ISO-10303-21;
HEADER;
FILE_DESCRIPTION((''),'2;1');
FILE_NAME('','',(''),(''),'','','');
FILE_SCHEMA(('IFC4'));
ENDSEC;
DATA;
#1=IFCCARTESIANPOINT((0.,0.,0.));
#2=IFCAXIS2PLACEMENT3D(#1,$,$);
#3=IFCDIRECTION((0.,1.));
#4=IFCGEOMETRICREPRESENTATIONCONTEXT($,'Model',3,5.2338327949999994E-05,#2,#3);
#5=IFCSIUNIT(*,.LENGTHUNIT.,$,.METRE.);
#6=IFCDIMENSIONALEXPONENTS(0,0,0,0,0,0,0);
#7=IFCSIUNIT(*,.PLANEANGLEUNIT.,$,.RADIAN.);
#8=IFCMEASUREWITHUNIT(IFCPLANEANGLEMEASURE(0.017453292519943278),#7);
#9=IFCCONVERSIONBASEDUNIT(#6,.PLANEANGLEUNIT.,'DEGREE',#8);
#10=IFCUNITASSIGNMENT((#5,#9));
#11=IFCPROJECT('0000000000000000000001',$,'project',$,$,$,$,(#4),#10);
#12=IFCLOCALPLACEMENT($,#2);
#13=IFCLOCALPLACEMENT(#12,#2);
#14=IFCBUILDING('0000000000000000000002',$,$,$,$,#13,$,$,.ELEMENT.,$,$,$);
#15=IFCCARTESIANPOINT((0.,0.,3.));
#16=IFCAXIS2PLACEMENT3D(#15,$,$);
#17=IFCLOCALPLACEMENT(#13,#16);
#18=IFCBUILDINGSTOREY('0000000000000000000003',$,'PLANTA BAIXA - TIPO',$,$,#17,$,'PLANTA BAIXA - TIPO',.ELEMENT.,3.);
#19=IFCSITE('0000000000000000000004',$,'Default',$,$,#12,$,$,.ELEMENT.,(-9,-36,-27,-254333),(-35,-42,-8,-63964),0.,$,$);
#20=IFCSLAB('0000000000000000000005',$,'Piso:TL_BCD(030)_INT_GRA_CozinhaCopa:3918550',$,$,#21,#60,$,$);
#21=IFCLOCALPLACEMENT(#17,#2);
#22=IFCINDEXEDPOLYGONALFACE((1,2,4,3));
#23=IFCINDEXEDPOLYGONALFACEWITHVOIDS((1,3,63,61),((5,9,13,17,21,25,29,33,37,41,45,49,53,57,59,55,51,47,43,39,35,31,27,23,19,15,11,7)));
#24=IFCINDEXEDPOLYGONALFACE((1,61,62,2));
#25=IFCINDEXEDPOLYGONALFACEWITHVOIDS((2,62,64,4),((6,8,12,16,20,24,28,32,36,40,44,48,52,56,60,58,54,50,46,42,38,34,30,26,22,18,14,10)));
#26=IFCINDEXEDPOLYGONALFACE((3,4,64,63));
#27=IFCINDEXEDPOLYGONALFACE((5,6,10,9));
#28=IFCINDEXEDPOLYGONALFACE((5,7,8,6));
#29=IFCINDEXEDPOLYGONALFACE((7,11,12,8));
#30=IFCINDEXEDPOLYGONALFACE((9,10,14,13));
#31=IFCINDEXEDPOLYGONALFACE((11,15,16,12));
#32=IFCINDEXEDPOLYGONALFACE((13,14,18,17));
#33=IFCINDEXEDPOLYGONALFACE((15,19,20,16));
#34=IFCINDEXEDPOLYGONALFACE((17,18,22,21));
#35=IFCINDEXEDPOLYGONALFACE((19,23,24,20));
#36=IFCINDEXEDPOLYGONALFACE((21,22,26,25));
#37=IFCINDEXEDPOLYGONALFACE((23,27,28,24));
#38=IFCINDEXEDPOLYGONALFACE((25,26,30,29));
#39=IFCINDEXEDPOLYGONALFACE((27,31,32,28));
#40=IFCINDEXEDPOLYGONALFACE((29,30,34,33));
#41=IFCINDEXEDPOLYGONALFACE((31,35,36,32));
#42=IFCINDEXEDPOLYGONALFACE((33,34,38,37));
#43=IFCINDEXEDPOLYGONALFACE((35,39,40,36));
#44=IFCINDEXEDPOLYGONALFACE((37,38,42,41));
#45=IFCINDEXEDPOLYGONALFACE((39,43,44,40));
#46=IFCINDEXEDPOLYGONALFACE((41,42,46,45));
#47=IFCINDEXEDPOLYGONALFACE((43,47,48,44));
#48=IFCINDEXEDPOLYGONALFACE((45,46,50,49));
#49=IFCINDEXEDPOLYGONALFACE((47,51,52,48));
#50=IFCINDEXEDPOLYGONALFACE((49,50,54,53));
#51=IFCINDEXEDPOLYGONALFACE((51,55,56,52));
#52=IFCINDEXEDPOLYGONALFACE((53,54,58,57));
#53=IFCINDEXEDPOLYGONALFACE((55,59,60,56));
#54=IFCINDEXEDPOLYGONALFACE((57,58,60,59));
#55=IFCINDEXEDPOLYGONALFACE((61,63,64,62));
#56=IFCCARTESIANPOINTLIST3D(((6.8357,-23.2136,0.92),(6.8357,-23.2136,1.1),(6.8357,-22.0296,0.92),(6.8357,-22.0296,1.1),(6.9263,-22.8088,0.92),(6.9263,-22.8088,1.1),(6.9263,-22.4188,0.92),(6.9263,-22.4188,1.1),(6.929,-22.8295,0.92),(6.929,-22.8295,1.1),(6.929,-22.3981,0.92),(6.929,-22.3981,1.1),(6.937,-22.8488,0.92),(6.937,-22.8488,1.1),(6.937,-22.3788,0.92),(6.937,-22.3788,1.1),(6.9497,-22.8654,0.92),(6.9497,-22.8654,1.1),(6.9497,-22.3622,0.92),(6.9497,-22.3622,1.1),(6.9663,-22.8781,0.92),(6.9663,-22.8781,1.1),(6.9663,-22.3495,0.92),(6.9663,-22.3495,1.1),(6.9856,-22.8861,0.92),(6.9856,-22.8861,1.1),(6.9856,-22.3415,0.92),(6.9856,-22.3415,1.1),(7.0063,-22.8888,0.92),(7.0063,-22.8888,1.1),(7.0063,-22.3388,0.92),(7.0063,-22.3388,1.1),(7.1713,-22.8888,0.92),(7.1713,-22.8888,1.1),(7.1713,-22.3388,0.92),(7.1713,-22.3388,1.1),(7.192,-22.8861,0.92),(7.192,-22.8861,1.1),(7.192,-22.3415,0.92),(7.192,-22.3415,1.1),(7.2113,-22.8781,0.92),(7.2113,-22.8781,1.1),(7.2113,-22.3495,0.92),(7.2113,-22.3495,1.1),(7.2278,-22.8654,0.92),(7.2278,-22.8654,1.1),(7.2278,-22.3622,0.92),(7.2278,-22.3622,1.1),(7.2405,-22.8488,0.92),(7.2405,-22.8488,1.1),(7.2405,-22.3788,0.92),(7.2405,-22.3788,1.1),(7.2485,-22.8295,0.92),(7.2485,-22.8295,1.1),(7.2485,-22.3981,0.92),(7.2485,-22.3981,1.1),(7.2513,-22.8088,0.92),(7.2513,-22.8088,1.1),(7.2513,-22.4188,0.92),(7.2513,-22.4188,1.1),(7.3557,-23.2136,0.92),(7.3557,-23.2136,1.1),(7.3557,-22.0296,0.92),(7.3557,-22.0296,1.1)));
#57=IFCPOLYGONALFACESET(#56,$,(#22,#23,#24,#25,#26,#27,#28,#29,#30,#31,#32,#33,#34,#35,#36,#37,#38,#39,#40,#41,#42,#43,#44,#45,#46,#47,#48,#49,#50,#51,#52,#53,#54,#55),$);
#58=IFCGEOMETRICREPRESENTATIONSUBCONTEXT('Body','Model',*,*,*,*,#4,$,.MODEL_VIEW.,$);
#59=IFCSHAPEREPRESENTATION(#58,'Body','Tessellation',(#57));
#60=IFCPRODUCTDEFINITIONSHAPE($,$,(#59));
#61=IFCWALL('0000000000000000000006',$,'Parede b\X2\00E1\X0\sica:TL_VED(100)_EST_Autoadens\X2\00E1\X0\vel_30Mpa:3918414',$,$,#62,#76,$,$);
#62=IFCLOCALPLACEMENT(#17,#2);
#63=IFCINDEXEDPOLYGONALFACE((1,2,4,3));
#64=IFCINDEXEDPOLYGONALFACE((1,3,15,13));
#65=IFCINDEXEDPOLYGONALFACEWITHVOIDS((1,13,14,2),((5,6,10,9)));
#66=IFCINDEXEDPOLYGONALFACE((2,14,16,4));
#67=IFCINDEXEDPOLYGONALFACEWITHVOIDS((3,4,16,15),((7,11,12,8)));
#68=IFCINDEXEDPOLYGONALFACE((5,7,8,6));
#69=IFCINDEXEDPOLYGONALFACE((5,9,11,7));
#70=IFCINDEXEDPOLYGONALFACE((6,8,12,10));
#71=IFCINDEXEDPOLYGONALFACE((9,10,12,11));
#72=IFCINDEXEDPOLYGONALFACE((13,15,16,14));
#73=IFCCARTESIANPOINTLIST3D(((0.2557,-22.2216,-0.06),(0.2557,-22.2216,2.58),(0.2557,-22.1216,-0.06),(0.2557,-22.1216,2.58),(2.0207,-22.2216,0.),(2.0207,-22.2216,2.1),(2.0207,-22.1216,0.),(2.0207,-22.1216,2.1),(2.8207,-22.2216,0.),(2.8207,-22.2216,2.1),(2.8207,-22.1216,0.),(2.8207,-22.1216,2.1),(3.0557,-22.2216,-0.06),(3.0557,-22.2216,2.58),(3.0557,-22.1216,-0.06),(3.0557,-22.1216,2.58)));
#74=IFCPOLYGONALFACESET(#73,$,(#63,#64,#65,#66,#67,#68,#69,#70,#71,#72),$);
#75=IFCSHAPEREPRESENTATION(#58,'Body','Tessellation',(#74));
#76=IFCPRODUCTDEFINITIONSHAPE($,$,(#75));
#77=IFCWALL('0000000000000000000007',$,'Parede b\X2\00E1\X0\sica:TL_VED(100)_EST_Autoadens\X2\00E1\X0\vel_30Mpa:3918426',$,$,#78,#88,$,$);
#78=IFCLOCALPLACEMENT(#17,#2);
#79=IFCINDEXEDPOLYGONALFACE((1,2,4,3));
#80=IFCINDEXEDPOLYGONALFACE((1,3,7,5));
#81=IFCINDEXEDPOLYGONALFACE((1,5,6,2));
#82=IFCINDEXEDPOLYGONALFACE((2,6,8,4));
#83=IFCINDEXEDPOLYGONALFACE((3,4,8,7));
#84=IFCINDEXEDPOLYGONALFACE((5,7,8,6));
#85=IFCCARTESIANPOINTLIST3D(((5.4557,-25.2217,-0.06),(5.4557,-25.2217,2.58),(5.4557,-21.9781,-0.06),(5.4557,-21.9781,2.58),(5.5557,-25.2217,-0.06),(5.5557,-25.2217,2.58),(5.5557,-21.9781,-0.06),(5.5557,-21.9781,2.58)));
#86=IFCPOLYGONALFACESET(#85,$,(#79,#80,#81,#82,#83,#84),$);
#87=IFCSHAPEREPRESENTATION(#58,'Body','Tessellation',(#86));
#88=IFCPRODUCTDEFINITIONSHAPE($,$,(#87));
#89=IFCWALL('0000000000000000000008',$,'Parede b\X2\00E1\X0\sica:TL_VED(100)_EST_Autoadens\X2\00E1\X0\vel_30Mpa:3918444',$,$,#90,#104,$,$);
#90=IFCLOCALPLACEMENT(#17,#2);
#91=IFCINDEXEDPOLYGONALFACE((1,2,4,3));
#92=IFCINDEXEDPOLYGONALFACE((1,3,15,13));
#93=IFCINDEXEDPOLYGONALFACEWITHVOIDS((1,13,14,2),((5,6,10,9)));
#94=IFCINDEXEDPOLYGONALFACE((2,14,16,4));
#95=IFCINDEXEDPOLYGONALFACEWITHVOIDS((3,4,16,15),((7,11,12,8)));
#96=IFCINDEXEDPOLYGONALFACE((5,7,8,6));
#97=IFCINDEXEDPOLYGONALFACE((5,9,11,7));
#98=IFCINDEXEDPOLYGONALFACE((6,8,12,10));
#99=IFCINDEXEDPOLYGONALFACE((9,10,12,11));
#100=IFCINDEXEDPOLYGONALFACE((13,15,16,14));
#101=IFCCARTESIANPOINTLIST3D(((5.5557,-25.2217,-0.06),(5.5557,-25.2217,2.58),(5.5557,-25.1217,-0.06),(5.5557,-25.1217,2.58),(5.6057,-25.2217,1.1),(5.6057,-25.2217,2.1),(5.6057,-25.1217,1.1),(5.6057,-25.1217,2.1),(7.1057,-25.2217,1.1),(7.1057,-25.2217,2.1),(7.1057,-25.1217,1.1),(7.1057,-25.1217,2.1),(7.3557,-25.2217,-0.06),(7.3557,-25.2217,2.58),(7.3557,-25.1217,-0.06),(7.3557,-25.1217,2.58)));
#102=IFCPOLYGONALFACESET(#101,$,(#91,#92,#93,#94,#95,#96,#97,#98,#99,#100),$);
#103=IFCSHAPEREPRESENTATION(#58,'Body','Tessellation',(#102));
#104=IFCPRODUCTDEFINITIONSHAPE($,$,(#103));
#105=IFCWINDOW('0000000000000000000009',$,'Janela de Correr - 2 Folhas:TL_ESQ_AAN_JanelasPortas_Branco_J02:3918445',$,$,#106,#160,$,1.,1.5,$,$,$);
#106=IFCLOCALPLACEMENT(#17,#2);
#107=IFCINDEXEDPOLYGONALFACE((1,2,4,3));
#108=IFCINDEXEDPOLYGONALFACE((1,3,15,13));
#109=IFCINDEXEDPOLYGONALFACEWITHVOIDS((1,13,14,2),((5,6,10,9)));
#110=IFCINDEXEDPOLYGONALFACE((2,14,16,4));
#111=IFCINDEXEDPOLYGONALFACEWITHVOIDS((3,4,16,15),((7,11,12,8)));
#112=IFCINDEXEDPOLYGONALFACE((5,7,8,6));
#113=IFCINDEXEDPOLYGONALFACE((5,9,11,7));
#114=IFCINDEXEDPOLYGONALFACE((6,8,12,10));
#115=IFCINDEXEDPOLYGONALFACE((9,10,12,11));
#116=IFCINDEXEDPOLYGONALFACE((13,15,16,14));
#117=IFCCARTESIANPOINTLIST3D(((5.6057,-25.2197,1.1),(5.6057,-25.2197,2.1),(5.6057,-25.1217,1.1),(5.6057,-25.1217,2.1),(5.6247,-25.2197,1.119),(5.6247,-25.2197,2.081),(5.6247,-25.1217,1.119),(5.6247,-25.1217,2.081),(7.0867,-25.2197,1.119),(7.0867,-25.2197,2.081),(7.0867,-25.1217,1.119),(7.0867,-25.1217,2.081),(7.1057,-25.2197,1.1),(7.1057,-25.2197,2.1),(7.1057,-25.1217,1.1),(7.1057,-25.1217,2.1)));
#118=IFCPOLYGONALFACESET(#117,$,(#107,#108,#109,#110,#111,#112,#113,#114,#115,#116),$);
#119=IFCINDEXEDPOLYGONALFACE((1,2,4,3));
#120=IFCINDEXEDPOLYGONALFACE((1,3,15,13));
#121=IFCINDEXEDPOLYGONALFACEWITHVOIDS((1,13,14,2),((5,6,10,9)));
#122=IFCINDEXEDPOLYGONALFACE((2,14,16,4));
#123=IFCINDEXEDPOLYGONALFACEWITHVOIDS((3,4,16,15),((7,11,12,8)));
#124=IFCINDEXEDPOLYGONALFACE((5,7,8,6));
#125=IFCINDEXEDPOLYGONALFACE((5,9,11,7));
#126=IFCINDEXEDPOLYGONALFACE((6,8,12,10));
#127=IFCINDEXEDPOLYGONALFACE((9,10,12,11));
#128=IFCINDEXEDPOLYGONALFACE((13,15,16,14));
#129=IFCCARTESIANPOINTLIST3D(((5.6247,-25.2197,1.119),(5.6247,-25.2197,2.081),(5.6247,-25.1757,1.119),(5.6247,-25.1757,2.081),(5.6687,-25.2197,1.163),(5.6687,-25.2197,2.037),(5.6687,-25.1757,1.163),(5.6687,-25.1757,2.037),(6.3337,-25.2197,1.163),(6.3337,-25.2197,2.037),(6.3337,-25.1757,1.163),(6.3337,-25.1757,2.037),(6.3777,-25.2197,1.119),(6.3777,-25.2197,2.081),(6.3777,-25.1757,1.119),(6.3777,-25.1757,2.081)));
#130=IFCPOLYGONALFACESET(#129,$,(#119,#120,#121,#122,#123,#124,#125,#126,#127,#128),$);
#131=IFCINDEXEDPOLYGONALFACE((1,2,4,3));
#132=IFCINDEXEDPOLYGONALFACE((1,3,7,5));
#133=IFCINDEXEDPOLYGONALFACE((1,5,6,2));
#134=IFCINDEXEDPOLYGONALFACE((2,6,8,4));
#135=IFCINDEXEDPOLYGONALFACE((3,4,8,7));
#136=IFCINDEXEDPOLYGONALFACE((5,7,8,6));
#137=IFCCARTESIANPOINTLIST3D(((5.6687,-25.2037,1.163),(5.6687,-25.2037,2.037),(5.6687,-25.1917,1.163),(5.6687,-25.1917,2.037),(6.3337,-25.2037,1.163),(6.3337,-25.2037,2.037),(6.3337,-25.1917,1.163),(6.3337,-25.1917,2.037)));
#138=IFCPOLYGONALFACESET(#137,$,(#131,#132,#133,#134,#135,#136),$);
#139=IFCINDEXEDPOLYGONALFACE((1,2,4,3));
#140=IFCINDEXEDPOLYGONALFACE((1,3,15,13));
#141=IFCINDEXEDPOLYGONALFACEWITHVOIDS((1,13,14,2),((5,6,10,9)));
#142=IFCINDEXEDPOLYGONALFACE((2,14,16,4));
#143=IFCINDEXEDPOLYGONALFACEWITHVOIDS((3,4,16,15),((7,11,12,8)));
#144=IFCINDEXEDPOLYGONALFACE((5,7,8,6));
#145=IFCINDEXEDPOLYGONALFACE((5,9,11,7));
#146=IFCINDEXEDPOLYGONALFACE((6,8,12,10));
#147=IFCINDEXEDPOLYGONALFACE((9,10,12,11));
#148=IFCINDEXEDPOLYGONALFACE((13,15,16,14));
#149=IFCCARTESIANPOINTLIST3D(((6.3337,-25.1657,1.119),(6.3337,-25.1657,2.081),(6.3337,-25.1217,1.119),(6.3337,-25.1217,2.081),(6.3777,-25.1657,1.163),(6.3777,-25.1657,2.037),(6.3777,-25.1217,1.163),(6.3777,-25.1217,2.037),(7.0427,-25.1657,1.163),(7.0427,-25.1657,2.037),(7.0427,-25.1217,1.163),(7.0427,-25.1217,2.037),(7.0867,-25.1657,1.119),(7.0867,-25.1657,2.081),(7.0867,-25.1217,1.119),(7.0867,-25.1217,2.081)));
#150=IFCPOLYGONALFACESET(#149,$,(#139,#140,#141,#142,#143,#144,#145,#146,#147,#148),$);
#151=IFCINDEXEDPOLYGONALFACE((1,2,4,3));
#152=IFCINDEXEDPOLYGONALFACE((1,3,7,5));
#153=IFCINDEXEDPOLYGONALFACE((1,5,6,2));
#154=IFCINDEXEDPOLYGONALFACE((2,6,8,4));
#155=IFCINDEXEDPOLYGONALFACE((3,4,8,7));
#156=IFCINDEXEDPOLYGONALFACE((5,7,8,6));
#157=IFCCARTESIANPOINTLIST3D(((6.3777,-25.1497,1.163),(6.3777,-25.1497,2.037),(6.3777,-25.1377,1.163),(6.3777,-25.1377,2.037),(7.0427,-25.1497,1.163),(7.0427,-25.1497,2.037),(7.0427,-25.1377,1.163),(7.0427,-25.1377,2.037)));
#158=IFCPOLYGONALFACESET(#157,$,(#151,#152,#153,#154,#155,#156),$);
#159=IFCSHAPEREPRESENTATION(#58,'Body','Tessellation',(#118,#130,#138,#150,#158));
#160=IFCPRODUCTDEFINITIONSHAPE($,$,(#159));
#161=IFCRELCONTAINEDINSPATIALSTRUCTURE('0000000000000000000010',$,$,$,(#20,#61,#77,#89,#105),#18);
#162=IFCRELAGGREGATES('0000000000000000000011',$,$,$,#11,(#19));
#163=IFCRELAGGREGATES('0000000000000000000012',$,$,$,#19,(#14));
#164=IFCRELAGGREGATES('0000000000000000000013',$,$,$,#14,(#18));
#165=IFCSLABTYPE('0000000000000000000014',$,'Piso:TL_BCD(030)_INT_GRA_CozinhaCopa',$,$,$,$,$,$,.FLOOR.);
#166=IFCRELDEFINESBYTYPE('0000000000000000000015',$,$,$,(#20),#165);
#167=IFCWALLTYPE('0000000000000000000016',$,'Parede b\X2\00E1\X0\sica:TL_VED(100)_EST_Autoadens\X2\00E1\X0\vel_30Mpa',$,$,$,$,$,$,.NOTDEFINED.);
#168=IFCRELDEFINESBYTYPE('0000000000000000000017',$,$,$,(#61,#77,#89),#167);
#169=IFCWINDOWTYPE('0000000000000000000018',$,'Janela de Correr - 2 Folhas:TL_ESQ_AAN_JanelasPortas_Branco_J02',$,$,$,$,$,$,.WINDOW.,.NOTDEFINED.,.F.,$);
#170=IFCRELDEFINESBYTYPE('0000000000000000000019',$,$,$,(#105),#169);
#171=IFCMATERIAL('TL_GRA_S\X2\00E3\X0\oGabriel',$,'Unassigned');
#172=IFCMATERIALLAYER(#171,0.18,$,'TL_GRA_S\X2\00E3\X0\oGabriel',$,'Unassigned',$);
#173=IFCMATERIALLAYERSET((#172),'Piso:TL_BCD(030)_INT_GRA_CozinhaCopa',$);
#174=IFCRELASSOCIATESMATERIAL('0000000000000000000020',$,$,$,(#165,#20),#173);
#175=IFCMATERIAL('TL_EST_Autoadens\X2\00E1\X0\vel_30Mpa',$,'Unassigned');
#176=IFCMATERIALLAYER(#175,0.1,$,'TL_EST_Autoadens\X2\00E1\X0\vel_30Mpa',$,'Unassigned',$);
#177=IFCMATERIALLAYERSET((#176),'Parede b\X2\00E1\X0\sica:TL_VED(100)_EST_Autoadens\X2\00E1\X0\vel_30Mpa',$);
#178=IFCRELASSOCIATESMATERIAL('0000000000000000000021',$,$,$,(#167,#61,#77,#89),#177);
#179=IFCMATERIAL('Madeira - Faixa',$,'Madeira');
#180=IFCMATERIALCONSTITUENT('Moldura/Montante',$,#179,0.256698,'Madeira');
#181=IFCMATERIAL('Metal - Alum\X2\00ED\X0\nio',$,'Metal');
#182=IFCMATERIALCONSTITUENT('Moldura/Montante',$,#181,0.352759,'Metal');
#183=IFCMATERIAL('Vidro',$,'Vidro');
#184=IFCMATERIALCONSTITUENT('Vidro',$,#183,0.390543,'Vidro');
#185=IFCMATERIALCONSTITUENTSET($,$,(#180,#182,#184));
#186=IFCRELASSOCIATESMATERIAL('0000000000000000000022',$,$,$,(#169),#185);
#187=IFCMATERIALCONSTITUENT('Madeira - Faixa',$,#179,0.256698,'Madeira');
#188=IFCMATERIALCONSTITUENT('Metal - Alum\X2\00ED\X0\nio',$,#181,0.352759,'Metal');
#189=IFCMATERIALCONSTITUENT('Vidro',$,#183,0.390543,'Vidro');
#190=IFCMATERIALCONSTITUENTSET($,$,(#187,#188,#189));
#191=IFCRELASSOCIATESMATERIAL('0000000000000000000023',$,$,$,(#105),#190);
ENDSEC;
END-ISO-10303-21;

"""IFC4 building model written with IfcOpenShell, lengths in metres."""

from ifc_helpers import new_model, entity, si_unit, converted_unit, direction, frame, frame_2d, origin, origin_2d_with_axis, place, context, subcontext, project, spatial, polyline, circle_curve, parameter, trimmed, segment, composite_curve, rectangle, outline, extrude, source, transform, mapped, material, layer, layer_set, layer_usage, constituent, constituent_set, type_object, type_shapes, element, fill, save


model = new_model("IFC4")

# Units and contexts
model_context = context("Model", 3, precision=5.2338327949999994e-05, world=origin(), true_north=direction((0.0, 1.0)))
body_context = subcontext(model_context, "Body", "Model", "MODEL_VIEW")
ifc_project = project(units=[si_unit("LENGTHUNIT", "METRE"), converted_unit("PLANEANGLEUNIT", "DEGREE", entity("IfcPlaneAngleMeasure", 0.017453292519943278), si_unit("PLANEANGLEUNIT", "RADIAN"), dimensions=[0, 0, 0, 0, 0, 0, 0])], contexts=[model_context])

# Site, building, storey
site_placement = place(None, frame((0.0, 0.0, 0.0)))
site = spatial("IfcSite", under=ifc_project, at=site_placement, Name="Default", CompositionType="ELEMENT", RefLatitude=(-9, -36, -27, -254333), RefLongitude=(-35, -42, -8, -63964), RefElevation=0.0)
building_placement = place(site_placement, origin())
building = spatial("IfcBuilding", under=site, at=building_placement, CompositionType="ELEMENT")
storey_placement = place(building_placement, frame((0.0, 0.0, 3.0)))
storey = spatial("IfcBuildingStorey", under=building, at=storey_placement, Name="PLANTA BAIXA - TIPO", LongName="PLANTA BAIXA - TIPO", CompositionType="ELEMENT", Elevation=3.0)

# Slab, opening
ifc_material_1 = material(Name="TL_GRA_SãoGabriel", Category="Unassigned")
ifc_layer_1 = layer(ifc_material_1, 0.18, Name="TL_GRA_SãoGabriel", Category="Unassigned")
ifc_layer_set_1 = layer_set([ifc_layer_1], Name="Piso:TL_BCD(030)_INT_GRA_CozinhaCopa")
ifc_layer_usage_1 = layer_usage(ifc_layer_set_1, "AXIS3", "POSITIVE", 0.0)
slab_type = type_object("IfcSlabType", Name="Piso:TL_BCD(030)_INT_GRA_CozinhaCopa", PredefinedType="FLOOR", material=ifc_layer_set_1)
slab_placement = place(storey_placement, frame((6.8357, -23.2136, 0.92)))
slab = element("IfcSlab", 1, at=slab_placement, inside=storey, type_object=slab_type, material=ifc_layer_usage_1, Name="Piso:TL_BCD(030)_INT_GRA_CozinhaCopa:3918550", context=body_context, shape_type="SweptSolid", body=[
    extrude(rectangle(XDim=0.52, YDim=1.184, at=origin_2d_with_axis()), frame((0.26, 0.592, 0.18), z_axis=(0.0, 0.0, -1.0), x_axis=(-1.0, 0.0, 0.0)), (0.0, 0.0, 1.0), 0.18),
])
opening_1_placement = place(slab_placement, frame((-6.8357, 23.2136, 0.18)))
element("IfcOpeningElement", 2, at=opening_1_placement, cuts=slab, PredefinedType="OPENING", context=body_context, shape_type="SweptSolid", body=[
    extrude(outline(composite_curve([segment(trimmed(circle_curve(frame_2d((0.195, -0.0825), x_axis=(1.0, 0.0)), 0.08), [parameter(270.0)], [parameter(0.0)], True, "PARAMETER"), True, "CONTINUOUS"), segment(polyline([(0.275, -0.0825), (0.275, 0.0825)]), True, "CONTINUOUS"), segment(trimmed(circle_curve(frame_2d((0.195, 0.0825), x_axis=(1.0, 0.0)), 0.08), [parameter(0.0)], [parameter(90.0)], True, "PARAMETER"), True, "CONTINUOUS"), segment(polyline([(0.195, 0.1625), (-0.195, 0.1625)]), True, "CONTINUOUS"), segment(trimmed(circle_curve(frame_2d((-0.195, 0.0825), x_axis=(1.0, 0.0)), 0.08), [parameter(90.0)], [parameter(180.0)], True, "PARAMETER"), True, "CONTINUOUS"), segment(polyline([(-0.275, 0.0825), (-0.275, -0.0825)]), True, "CONTINUOUS"), segment(trimmed(circle_curve(frame_2d((-0.195, -0.0825), x_axis=(1.0, 0.0)), 0.08), [parameter(180.0)], [parameter(270.0)], True, "PARAMETER"), True, "CONTINUOUS"), segment(polyline([(-0.195, -0.1625), (0.195, -0.1625)]), True, "CONTINUOUS")], self_intersect=False)), frame((7.0888, -22.6138, -0.21), z_axis=(0.0, 0.0, 1.0), x_axis=(0.0, 1.0, 0.0)), (0.0, 0.0, 1.0), 0.21),
])

# Wall, opening
ifc_material_2 = material(Name="TL_EST_Autoadensável_30Mpa", Category="Unassigned")
ifc_layer_2 = layer(ifc_material_2, 0.1, Name="TL_EST_Autoadensável_30Mpa", Category="Unassigned")
ifc_layer_set_2 = layer_set([ifc_layer_2], Name="Parede básica:TL_VED(100)_EST_Autoadensável_30Mpa")
ifc_layer_usage_2 = layer_usage(ifc_layer_set_2, "AXIS2", "NEGATIVE", 0.05)
wall_type_1 = type_object("IfcWallType", Name="Parede básica:TL_VED(100)_EST_Autoadensável_30Mpa", PredefinedType="NOTDEFINED", material=ifc_layer_set_2)
wall_1_placement = place(storey_placement, frame((3.0557, -22.1716, -0.06), z_axis=(0.0, 0.0, 1.0), x_axis=(-1.0, 0.0, 0.0)))
wall_1 = element("IfcWall", 3, at=wall_1_placement, inside=storey, type_object=wall_type_1, material=ifc_layer_usage_2, Name="Parede básica:TL_VED(100)_EST_Autoadensável_30Mpa:3918414", context=body_context, shape_type="SweptSolid", body=[
    extrude(rectangle(XDim=2.8, YDim=0.1, at=frame_2d((1.4, 0.0), x_axis=(-1.0, 0.0))), origin(), (0.0, 0.0, 1.0), 2.64),
])
opening_2_placement = place(wall_1_placement, frame((0.235, -0.05, 0.06)))
element("IfcOpeningElement", 4, at=opening_2_placement, cuts=wall_1, PredefinedType="OPENING", context=body_context, shape_type="SweptSolid", body=[
    extrude(rectangle(XDim=2.1, YDim=0.8, at=frame_2d((1.05, 0.4), x_axis=(1.0, 0.0))), frame((0.0, 0.0, 0.0), z_axis=(0.0, 1.0, 0.0), x_axis=(0.0, 0.0, 1.0)), (0.0, 0.0, 1.0), 0.1),
])

# Wall
ifc_layer_usage_3 = layer_usage(ifc_layer_set_2, "AXIS2", "POSITIVE", -0.05)
wall_2_placement = place(storey_placement, frame((5.5057, -25.2217, -0.06), z_axis=(0.0, 0.0, 1.0), x_axis=(0.0, 1.0, 0.0)))
element("IfcWall", 5, at=wall_2_placement, inside=storey, type_object=wall_type_1, material=ifc_layer_usage_3, Name="Parede básica:TL_VED(100)_EST_Autoadensável_30Mpa:3918426", context=body_context, shape_type="SweptSolid", body=[
    extrude(rectangle(XDim=3.2437, YDim=0.1, at=frame_2d((1.6218, 0.0), x_axis=(-1.0, 0.0))), origin(), (0.0, 0.0, 1.0), 2.64),
])

# Wall, opening, window
ifc_layer_usage_4 = layer_usage(ifc_layer_set_2, "AXIS2", "POSITIVE", -0.05)
wall_3_placement = place(storey_placement, frame((5.5557, -25.1717, -0.06)))
wall_3 = element("IfcWall", 6, at=wall_3_placement, inside=storey, type_object=wall_type_1, material=ifc_layer_usage_4, Name="Parede básica:TL_VED(100)_EST_Autoadensável_30Mpa:3918444", context=body_context, shape_type="SweptSolid", body=[
    extrude(rectangle(XDim=1.8, YDim=0.1, at=frame_2d((0.9, 0.0), x_axis=(-1.0, 0.0))), origin(), (0.0, 0.0, 1.0), 2.64),
])
opening_3_placement = place(wall_3_placement, frame((1.55, 0.05, 1.16)))
opening_3 = element("IfcOpeningElement", 7, at=opening_3_placement, cuts=wall_3, PredefinedType="OPENING", context=body_context, shape_type="SweptSolid", body=[
    extrude(rectangle(XDim=1.0, YDim=1.5, at=frame_2d((0.5, 0.75), x_axis=(-1.0, 0.0))), frame((0.0, 0.0, 0.0), z_axis=(0.0, -1.0, 0.0), x_axis=(0.0, 0.0, 1.0)), (0.0, 0.0, 1.0), 0.1),
])
ifc_material_3 = material(Name="Madeira - Faixa", Category="Madeira")
ifc_constituent_1 = constituent(ifc_material_3, Name="Madeira - Faixa", Category="Madeira", fraction=0.256698)
ifc_material_4 = material(Name="Metal - Alumínio", Category="Metal")
ifc_constituent_2 = constituent(ifc_material_4, Name="Metal - Alumínio", Category="Metal", fraction=0.352759)
ifc_material_5 = material(Name="Vidro", Category="Vidro")
ifc_constituent_3 = constituent(ifc_material_5, Name="Vidro", Category="Vidro", fraction=0.390543)
ifc_constituent_set_1 = constituent_set(constituents=[ifc_constituent_1, ifc_constituent_2, ifc_constituent_3])
ifc_constituent_4 = constituent(ifc_material_3, Name="Moldura/Montante", Category="Madeira", fraction=0.256698)
ifc_constituent_5 = constituent(ifc_material_4, Name="Moldura/Montante", Category="Metal", fraction=0.352759)
ifc_constituent_6 = constituent(ifc_material_5, Name="Vidro", Category="Vidro", fraction=0.390543)
ifc_constituent_set_2 = constituent_set(constituents=[ifc_constituent_4, ifc_constituent_5, ifc_constituent_6])
window_type_1 = type_object("IfcWindowType", Name="Janela de Correr - 2 Folhas:TL_ESQ_AAN_JanelasPortas_Branco_J02", ParameterTakesPrecedence=False, PartitioningType="NOTDEFINED", PredefinedType="WINDOW", material=ifc_constituent_set_2)
shared_shape_1 = source(origin(), body_context, "Body", "SweptSolid", [
    extrude(outline(polyline([(-0.75, -0.5), (0.75, -0.5), (0.75, 0.5), (-0.75, 0.5), (-0.75, -0.5)]), holes=[polyline([(-0.731, -0.481), (-0.731, 0.481), (0.731, 0.481), (0.731, -0.481), (-0.731, -0.481)])]), frame((0.75, 0.0, 0.5), z_axis=(0.0, 1.0, 0.0), x_axis=(1.0, 0.0, 0.0)), (0.0, 0.0, 1.0), 0.098),
    extrude(outline(polyline([(-0.3765, -0.481), (0.3765, -0.481), (0.3765, 0.481), (-0.3765, 0.481), (-0.3765, -0.481)]), holes=[polyline([(-0.3325, -0.437), (-0.3325, 0.437), (0.3325, 0.437), (0.3325, -0.437), (-0.3325, -0.437)])]), frame((1.1045, 0.054, 0.5), z_axis=(0.0, 1.0, 0.0), x_axis=(1.0, 0.0, 0.0)), (0.0, 0.0, 1.0), 0.044),
    extrude(rectangle(XDim=0.012, YDim=0.665, at=origin_2d_with_axis()), frame((1.1045, 0.076, 0.063), z_axis=(0.0, 0.0, 1.0), x_axis=(0.0, -1.0, 0.0)), (0.0, 0.0, 1.0), 0.874),
    extrude(outline(polyline([(-0.481, -0.3765), (0.481, -0.3765), (0.481, 0.3765), (-0.481, 0.3765), (-0.481, -0.3765)]), holes=[polyline([(-0.437, -0.3325), (-0.437, 0.3325), (0.437, 0.3325), (0.437, -0.3325), (-0.437, -0.3325)])]), frame((0.3955, 0.0, 0.5), z_axis=(0.0, 1.0, 0.0), x_axis=(0.0, 0.0, -1.0)), (0.0, 0.0, 1.0), 0.044),
    extrude(rectangle(XDim=0.012, YDim=0.665, at=origin_2d_with_axis()), frame((0.3955, 0.022, 0.063), z_axis=(0.0, 0.0, 1.0), x_axis=(0.0, -1.0, 0.0)), (0.0, 0.0, 1.0), 0.874),
])
type_shapes(window_type_1, [shared_shape_1])
window_1_placement = place(opening_3_placement, frame((0.0, 0.0, 0.0), z_axis=(0.0, 0.0, 1.0), x_axis=(-1.0, 0.0, 0.0)))
window_1 = element("IfcWindow", 8, at=window_1_placement, inside=storey, type_object=window_type_1, material=ifc_constituent_set_1, Name="Janela de Correr - 2 Folhas:TL_ESQ_AAN_JanelasPortas_Branco_J02:3918445", OverallHeight=1.0, OverallWidth=1.5, context=body_context, shape_type="MappedRepresentation", body=[
    mapped(shared_shape_1, transform((0.0, 0.0, 0.0), scale=1.0)),
])
fill(opening_3, window_1)

save(model, "model.ifc")
